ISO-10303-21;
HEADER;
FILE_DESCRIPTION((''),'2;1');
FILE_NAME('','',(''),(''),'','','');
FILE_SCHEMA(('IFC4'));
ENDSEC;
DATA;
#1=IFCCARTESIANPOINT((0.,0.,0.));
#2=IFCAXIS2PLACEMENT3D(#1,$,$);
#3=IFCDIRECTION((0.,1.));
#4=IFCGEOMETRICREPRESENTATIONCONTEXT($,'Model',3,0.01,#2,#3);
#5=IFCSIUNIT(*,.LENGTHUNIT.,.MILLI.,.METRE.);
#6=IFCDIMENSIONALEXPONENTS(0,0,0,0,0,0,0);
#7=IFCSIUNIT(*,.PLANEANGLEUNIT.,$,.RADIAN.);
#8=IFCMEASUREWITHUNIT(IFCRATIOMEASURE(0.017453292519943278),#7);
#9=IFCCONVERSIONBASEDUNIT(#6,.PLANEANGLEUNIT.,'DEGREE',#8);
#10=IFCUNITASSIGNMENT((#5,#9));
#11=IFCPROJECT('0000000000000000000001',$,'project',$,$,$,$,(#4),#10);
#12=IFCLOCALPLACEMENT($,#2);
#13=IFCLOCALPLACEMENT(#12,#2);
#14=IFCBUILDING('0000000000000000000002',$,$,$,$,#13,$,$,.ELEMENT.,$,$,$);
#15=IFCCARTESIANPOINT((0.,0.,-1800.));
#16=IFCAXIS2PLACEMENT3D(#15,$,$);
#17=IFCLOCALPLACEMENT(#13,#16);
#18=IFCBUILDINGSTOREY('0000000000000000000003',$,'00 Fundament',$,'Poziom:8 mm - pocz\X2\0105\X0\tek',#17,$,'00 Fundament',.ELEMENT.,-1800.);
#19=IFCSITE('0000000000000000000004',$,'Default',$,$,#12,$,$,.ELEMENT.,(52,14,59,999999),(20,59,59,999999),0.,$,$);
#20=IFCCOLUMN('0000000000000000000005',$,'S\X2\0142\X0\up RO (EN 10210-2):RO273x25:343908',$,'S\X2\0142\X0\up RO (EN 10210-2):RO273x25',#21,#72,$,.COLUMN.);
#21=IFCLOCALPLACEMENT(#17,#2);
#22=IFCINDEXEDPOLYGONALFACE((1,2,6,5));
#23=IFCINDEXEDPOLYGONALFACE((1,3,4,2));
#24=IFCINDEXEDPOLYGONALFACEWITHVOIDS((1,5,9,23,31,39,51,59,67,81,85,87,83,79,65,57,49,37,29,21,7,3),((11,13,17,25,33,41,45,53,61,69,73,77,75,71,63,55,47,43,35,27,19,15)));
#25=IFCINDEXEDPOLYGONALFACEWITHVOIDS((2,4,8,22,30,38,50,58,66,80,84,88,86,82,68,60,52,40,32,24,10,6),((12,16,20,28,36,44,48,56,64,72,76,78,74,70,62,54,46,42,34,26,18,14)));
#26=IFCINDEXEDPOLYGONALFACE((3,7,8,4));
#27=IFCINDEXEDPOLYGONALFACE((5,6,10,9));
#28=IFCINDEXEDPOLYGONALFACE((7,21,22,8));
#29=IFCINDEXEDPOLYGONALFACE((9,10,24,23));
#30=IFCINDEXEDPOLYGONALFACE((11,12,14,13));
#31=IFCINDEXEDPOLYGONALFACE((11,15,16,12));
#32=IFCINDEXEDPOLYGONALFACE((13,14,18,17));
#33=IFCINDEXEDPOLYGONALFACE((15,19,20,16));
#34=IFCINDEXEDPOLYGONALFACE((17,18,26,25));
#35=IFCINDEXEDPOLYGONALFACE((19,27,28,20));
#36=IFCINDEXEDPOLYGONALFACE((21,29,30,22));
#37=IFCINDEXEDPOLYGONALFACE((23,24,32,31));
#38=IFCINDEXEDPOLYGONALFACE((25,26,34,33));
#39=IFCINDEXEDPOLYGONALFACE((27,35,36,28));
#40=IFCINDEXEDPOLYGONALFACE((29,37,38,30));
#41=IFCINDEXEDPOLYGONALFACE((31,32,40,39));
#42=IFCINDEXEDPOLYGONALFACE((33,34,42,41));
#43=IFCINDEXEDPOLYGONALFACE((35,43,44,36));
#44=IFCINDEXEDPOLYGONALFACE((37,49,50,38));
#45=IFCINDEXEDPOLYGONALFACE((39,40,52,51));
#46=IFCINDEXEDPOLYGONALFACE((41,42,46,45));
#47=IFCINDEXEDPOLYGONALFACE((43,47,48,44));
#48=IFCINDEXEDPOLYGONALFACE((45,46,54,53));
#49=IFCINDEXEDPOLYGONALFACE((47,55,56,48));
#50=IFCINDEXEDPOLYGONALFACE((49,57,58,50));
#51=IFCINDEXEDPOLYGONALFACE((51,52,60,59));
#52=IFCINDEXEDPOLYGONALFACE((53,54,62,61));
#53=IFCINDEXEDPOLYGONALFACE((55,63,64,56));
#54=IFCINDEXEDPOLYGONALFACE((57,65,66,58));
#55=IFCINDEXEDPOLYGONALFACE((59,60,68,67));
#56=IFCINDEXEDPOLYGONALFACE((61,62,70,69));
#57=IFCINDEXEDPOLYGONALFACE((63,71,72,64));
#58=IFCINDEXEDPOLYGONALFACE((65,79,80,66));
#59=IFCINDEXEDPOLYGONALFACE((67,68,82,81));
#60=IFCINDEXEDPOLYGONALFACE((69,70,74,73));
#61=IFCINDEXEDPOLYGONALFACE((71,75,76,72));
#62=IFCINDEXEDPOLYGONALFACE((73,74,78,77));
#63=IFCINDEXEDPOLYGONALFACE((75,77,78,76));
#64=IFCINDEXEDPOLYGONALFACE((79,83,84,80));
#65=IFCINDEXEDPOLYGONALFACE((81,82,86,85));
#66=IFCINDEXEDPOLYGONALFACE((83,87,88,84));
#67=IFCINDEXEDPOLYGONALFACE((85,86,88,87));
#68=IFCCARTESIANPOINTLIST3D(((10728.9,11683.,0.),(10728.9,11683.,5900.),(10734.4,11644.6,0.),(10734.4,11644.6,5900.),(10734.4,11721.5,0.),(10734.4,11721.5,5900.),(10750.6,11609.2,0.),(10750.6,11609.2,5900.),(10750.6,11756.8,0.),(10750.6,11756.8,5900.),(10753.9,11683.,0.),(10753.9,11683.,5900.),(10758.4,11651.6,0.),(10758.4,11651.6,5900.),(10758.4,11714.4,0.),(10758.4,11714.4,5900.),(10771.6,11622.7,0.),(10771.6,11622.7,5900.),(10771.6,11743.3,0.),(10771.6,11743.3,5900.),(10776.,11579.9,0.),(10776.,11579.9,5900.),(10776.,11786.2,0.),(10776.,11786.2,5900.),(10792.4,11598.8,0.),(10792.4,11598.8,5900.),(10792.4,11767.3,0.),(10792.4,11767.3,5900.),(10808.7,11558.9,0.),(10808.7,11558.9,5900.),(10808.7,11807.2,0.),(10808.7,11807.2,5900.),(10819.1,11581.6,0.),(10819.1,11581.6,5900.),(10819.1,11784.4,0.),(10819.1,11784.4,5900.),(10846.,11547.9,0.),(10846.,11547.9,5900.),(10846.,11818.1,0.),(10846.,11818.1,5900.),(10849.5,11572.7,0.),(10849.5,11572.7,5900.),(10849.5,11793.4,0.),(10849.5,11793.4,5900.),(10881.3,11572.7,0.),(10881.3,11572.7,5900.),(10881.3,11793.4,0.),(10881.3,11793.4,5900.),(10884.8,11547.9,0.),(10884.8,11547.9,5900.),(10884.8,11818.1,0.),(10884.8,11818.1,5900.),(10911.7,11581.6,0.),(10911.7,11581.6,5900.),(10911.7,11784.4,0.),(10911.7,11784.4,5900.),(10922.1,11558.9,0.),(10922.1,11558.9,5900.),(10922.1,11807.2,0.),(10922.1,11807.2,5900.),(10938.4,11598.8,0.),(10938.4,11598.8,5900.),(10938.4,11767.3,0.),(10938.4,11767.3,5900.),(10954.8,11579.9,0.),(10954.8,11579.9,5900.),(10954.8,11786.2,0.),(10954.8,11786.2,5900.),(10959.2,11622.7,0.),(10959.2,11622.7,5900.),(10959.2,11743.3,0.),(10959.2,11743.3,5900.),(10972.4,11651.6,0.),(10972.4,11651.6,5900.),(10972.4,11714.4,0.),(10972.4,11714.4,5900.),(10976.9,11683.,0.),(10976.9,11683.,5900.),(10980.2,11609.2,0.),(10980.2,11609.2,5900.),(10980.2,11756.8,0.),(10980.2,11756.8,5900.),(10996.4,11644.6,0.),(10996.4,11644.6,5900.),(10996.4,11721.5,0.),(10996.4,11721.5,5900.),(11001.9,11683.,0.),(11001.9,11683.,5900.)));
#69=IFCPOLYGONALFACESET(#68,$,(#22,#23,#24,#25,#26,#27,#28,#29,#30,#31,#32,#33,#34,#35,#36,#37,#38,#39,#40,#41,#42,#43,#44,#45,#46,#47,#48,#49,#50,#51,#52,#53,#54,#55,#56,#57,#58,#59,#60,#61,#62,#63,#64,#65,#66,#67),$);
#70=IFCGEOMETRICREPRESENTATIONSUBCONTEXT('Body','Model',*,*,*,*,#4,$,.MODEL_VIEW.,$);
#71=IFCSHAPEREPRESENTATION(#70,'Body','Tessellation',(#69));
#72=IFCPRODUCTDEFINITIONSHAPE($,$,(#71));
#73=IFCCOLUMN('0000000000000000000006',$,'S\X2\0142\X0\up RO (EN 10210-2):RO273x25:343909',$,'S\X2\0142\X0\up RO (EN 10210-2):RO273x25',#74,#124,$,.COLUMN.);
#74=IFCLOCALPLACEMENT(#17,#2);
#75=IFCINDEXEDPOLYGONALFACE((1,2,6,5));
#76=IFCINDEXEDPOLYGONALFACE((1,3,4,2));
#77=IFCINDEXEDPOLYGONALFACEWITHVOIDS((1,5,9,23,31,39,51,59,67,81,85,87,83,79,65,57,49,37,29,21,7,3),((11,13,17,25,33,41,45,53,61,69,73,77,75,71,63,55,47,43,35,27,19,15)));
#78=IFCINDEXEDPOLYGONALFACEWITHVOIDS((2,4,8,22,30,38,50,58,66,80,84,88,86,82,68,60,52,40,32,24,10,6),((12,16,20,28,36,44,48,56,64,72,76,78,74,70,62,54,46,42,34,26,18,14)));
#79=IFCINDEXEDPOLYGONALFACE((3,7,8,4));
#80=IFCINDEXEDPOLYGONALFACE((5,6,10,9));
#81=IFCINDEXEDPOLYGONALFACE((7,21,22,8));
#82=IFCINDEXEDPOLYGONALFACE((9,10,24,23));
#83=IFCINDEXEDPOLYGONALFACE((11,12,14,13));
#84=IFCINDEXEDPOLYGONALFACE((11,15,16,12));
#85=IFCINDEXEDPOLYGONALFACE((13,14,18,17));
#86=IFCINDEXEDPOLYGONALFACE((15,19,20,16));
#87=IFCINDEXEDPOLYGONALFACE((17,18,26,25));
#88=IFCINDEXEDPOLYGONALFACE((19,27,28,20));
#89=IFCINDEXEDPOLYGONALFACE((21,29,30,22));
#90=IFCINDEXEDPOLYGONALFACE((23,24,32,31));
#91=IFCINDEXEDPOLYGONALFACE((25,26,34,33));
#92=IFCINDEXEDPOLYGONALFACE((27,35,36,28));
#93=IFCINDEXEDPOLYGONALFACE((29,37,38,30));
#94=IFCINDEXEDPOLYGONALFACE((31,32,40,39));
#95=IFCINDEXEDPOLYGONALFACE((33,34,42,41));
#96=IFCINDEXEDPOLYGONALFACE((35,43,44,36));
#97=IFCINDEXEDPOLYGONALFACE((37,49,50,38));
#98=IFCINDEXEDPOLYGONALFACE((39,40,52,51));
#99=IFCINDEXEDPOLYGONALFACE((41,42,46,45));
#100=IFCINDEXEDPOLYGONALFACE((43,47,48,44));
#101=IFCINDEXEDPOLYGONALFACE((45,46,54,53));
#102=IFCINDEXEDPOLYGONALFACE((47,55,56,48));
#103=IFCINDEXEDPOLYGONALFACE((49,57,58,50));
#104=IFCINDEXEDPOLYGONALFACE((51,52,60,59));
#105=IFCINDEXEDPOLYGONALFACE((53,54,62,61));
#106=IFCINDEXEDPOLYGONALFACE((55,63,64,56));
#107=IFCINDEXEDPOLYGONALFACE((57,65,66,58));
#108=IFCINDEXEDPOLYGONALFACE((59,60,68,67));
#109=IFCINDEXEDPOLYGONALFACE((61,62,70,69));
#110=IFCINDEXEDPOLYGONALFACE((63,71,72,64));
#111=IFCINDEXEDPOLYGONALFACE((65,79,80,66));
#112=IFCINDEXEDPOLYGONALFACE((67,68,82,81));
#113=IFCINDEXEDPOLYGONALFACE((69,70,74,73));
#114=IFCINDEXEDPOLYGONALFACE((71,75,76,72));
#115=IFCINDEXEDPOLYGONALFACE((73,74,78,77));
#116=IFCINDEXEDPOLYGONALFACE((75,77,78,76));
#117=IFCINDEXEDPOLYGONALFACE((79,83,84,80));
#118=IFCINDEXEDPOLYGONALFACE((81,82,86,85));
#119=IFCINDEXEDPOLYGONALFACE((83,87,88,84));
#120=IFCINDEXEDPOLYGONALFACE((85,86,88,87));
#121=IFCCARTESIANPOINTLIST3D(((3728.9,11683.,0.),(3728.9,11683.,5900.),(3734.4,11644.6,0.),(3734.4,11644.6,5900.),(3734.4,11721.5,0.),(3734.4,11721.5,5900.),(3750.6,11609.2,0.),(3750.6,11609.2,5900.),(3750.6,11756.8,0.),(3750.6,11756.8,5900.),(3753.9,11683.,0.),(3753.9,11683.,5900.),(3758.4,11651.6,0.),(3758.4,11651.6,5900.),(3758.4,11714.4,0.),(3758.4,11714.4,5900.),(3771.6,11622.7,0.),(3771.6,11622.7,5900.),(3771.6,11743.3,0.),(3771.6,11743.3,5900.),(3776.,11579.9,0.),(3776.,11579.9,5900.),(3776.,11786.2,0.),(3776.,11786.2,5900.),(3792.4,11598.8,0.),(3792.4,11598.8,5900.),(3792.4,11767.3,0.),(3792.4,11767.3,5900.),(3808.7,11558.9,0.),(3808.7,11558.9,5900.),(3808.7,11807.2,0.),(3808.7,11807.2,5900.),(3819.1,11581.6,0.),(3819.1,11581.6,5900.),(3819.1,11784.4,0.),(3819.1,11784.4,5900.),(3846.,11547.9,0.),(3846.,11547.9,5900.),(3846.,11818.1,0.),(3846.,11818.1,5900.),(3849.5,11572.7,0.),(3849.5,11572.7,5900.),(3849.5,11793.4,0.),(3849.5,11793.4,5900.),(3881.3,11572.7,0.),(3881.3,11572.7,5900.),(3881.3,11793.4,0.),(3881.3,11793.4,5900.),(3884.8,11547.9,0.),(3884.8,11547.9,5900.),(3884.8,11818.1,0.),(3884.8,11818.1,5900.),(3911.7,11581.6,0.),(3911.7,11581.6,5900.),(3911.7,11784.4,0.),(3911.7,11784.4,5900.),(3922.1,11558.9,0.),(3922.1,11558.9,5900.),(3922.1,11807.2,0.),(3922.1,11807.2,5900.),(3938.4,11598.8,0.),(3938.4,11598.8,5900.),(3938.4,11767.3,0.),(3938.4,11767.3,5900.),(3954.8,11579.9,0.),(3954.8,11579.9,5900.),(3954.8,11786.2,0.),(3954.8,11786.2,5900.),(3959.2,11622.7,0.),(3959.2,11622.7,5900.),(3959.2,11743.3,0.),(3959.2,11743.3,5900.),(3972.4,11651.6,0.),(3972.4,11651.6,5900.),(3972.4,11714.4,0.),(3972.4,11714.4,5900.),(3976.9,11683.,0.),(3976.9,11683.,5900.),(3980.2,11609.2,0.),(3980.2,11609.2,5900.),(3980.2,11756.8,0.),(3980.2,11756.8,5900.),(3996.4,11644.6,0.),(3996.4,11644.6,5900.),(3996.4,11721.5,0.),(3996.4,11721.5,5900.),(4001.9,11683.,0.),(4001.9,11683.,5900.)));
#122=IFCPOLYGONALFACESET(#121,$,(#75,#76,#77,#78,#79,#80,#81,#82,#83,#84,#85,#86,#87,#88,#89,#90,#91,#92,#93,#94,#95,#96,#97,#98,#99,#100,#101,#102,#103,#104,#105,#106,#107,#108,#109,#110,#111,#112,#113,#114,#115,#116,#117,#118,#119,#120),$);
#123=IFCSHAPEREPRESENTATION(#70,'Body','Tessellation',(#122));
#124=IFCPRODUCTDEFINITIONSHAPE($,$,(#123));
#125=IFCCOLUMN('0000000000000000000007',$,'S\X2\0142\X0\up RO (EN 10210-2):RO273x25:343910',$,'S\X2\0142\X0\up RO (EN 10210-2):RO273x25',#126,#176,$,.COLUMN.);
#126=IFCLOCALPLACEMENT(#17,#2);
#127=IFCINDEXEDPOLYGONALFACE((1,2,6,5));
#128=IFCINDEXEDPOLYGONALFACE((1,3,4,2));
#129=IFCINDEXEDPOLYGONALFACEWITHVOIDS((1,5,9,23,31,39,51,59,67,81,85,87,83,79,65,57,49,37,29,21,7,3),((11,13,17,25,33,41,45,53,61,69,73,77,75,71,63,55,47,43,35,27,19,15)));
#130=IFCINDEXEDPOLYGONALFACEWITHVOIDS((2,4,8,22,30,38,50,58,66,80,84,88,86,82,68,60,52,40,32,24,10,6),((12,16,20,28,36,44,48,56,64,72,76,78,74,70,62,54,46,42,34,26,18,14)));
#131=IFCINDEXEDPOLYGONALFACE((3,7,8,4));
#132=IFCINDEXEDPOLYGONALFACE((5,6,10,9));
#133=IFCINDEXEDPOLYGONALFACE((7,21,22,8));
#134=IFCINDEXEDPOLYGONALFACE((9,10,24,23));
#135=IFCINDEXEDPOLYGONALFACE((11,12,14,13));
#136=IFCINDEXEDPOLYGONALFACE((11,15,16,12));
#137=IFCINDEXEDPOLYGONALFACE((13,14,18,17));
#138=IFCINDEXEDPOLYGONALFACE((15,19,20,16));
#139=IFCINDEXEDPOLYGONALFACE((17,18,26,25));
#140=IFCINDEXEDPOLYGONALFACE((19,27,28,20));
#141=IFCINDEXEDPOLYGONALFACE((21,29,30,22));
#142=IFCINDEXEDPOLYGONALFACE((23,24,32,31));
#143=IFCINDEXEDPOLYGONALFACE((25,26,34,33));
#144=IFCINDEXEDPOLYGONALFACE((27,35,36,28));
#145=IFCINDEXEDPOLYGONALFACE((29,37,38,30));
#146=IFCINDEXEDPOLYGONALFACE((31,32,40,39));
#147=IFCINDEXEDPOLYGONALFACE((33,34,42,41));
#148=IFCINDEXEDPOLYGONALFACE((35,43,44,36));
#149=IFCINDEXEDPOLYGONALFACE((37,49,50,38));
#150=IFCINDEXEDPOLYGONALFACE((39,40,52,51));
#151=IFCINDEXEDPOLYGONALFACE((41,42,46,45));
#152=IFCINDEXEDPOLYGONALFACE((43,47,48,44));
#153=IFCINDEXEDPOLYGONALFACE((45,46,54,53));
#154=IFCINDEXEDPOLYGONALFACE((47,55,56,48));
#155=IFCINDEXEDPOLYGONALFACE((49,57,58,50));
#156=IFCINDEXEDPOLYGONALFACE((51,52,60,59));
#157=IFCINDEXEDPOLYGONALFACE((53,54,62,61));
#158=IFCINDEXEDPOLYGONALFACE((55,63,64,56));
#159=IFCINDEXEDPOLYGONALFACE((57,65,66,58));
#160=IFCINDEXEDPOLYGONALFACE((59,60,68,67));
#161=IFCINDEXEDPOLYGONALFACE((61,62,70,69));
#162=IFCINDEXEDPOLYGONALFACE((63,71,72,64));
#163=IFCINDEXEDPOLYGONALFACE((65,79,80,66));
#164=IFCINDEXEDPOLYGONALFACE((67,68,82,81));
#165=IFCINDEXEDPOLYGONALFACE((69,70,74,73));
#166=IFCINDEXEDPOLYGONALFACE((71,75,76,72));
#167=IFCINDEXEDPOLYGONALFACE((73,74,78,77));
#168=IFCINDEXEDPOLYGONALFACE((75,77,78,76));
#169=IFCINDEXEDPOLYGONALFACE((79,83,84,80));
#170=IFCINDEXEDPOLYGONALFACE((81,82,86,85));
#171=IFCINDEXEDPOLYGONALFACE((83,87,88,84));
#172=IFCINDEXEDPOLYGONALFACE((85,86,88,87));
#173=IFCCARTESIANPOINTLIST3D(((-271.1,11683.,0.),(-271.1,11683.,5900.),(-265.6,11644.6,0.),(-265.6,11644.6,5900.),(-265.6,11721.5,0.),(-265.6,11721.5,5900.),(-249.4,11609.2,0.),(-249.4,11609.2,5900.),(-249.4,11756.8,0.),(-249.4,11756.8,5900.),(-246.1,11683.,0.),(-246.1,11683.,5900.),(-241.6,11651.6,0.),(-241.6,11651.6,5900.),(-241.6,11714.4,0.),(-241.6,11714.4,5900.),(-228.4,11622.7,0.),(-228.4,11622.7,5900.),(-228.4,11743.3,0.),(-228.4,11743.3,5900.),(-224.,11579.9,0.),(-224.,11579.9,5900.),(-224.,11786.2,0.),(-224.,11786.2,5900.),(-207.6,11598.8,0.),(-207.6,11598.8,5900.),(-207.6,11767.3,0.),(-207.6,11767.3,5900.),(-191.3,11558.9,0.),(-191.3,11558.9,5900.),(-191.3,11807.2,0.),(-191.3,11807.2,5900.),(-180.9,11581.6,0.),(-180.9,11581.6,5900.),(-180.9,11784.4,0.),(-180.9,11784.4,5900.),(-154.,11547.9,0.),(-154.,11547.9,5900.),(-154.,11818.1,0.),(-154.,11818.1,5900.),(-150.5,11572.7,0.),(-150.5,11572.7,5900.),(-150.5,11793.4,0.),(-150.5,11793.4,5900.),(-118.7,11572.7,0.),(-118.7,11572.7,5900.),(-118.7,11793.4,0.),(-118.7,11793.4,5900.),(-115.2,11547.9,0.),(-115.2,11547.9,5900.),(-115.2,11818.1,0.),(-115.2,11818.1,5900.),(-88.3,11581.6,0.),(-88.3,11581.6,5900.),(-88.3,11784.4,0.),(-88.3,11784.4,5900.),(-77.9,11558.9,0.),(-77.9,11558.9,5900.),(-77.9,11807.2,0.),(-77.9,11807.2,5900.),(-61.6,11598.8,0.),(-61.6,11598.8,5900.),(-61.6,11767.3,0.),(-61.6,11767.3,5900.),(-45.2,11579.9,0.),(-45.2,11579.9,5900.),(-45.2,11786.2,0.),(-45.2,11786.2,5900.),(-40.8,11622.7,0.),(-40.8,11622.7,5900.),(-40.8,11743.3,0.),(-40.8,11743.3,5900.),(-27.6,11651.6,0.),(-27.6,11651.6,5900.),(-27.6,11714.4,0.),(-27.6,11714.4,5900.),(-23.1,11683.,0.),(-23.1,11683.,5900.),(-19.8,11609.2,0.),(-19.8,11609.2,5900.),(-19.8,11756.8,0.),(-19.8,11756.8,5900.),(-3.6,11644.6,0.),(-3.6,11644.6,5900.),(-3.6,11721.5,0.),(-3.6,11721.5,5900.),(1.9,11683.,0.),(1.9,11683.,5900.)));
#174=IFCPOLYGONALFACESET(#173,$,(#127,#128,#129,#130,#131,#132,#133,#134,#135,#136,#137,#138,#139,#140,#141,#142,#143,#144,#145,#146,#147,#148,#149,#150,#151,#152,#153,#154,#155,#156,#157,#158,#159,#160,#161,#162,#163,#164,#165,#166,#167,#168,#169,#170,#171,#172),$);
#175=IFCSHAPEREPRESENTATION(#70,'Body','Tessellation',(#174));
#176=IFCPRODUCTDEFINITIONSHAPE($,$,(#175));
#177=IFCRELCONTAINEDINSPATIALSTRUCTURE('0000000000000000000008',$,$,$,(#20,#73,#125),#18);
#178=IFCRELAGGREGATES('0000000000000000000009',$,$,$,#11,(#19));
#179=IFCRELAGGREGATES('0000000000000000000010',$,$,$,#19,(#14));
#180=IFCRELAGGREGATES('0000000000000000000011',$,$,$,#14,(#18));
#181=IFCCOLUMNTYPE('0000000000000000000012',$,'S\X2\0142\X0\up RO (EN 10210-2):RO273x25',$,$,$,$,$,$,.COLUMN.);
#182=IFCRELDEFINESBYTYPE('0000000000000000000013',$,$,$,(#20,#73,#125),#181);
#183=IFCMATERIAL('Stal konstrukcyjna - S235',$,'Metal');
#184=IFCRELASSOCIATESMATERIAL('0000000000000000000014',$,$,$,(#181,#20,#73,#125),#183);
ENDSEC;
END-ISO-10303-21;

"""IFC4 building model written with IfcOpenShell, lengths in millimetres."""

from ifc_helpers import new_model, entity, si_unit, converted_unit, direction, frame, origin, place, context, subcontext, project, spatial, arc, indexed_curve, outline, extrude, source, transform, mapped, material, type_object, type_shapes, element, save


model = new_model("IFC4")

# Units and contexts
model_context = context("Model", 3, precision=0.01, world=origin(), true_north=direction((0.0, 1.0)))
body_context = subcontext(model_context, "Body", "Model", "MODEL_VIEW")
ifc_project = project(units=[si_unit("LENGTHUNIT", "METRE", prefix="MILLI"), converted_unit("PLANEANGLEUNIT", "DEGREE", entity("IfcRatioMeasure", 0.017453292519943278), si_unit("PLANEANGLEUNIT", "RADIAN"), dimensions=[0, 0, 0, 0, 0, 0, 0])], contexts=[model_context])

# Site, building, storey
site_placement = place(None, origin())
site = spatial("IfcSite", under=ifc_project, at=site_placement, Name="Default", CompositionType="ELEMENT", RefLatitude=(52, 14, 59, 999999), RefLongitude=(20, 59, 59, 999999), RefElevation=0.0)
building_placement = place(site_placement, origin())
building = spatial("IfcBuilding", under=site, at=building_placement, CompositionType="ELEMENT")
storey_placement = place(building_placement, frame((0.0, 0.0, -1800.0)))
storey = spatial("IfcBuildingStorey", under=building, at=storey_placement, Name="00 Fundament", ObjectType="Poziom:8 mm - początek", LongName="00 Fundament", CompositionType="ELEMENT", Elevation=-1800.0)

# Columns
ifc_material_1 = material(Name="Stal konstrukcyjna - S235", Category="Metal")
column_type = type_object("IfcColumnType", Name="Słup RO (EN 10210-2):RO273x25", PredefinedType="COLUMN", material=ifc_material_1)
shared_shape = source(origin(), body_context, "Body", "SweptSolid", [
    extrude(outline(indexed_curve([(-136.5, 0.0), (0.0, -136.5), (136.5, 0.0), (0.0, 136.5)], segments=[arc(1, 2, 3), arc(3, 4, 1)], self_intersect=False), holes=[indexed_curve([(-111.5, 0.0), (0.0, 111.5), (111.5, 0.0), (0.0, -111.5)], segments=[arc(1, 2, 3), arc(3, 4, 1)], self_intersect=False)]), frame((0.0, 0.0, -1800.0)), (0.0, 0.0, 1.0), 5900.0),
])
type_shapes(column_type, [shared_shape])
for number, where, name in (
    (1, (10865.4, 11683.0, 1800.0), "Słup RO (EN 10210-2):RO273x25:343908"),
    (2, (3865.4, 11683.0, 1800.0), "Słup RO (EN 10210-2):RO273x25:343909"),
    (3, (-134.6, 11683.0, 1800.0), "Słup RO (EN 10210-2):RO273x25:343910"),
):
    element("IfcColumn", number, at=place(storey_placement, frame(where)), inside=storey, type_object=column_type, material=ifc_material_1, Name=name, ObjectType="Słup RO (EN 10210-2):RO273x25", PredefinedType="COLUMN", context=body_context, shape_type="MappedRepresentation", body=[
        mapped(shared_shape, transform((0.0, 0.0, 0.0), scale=1.0)),
    ])

save(model, "model.ifc")
